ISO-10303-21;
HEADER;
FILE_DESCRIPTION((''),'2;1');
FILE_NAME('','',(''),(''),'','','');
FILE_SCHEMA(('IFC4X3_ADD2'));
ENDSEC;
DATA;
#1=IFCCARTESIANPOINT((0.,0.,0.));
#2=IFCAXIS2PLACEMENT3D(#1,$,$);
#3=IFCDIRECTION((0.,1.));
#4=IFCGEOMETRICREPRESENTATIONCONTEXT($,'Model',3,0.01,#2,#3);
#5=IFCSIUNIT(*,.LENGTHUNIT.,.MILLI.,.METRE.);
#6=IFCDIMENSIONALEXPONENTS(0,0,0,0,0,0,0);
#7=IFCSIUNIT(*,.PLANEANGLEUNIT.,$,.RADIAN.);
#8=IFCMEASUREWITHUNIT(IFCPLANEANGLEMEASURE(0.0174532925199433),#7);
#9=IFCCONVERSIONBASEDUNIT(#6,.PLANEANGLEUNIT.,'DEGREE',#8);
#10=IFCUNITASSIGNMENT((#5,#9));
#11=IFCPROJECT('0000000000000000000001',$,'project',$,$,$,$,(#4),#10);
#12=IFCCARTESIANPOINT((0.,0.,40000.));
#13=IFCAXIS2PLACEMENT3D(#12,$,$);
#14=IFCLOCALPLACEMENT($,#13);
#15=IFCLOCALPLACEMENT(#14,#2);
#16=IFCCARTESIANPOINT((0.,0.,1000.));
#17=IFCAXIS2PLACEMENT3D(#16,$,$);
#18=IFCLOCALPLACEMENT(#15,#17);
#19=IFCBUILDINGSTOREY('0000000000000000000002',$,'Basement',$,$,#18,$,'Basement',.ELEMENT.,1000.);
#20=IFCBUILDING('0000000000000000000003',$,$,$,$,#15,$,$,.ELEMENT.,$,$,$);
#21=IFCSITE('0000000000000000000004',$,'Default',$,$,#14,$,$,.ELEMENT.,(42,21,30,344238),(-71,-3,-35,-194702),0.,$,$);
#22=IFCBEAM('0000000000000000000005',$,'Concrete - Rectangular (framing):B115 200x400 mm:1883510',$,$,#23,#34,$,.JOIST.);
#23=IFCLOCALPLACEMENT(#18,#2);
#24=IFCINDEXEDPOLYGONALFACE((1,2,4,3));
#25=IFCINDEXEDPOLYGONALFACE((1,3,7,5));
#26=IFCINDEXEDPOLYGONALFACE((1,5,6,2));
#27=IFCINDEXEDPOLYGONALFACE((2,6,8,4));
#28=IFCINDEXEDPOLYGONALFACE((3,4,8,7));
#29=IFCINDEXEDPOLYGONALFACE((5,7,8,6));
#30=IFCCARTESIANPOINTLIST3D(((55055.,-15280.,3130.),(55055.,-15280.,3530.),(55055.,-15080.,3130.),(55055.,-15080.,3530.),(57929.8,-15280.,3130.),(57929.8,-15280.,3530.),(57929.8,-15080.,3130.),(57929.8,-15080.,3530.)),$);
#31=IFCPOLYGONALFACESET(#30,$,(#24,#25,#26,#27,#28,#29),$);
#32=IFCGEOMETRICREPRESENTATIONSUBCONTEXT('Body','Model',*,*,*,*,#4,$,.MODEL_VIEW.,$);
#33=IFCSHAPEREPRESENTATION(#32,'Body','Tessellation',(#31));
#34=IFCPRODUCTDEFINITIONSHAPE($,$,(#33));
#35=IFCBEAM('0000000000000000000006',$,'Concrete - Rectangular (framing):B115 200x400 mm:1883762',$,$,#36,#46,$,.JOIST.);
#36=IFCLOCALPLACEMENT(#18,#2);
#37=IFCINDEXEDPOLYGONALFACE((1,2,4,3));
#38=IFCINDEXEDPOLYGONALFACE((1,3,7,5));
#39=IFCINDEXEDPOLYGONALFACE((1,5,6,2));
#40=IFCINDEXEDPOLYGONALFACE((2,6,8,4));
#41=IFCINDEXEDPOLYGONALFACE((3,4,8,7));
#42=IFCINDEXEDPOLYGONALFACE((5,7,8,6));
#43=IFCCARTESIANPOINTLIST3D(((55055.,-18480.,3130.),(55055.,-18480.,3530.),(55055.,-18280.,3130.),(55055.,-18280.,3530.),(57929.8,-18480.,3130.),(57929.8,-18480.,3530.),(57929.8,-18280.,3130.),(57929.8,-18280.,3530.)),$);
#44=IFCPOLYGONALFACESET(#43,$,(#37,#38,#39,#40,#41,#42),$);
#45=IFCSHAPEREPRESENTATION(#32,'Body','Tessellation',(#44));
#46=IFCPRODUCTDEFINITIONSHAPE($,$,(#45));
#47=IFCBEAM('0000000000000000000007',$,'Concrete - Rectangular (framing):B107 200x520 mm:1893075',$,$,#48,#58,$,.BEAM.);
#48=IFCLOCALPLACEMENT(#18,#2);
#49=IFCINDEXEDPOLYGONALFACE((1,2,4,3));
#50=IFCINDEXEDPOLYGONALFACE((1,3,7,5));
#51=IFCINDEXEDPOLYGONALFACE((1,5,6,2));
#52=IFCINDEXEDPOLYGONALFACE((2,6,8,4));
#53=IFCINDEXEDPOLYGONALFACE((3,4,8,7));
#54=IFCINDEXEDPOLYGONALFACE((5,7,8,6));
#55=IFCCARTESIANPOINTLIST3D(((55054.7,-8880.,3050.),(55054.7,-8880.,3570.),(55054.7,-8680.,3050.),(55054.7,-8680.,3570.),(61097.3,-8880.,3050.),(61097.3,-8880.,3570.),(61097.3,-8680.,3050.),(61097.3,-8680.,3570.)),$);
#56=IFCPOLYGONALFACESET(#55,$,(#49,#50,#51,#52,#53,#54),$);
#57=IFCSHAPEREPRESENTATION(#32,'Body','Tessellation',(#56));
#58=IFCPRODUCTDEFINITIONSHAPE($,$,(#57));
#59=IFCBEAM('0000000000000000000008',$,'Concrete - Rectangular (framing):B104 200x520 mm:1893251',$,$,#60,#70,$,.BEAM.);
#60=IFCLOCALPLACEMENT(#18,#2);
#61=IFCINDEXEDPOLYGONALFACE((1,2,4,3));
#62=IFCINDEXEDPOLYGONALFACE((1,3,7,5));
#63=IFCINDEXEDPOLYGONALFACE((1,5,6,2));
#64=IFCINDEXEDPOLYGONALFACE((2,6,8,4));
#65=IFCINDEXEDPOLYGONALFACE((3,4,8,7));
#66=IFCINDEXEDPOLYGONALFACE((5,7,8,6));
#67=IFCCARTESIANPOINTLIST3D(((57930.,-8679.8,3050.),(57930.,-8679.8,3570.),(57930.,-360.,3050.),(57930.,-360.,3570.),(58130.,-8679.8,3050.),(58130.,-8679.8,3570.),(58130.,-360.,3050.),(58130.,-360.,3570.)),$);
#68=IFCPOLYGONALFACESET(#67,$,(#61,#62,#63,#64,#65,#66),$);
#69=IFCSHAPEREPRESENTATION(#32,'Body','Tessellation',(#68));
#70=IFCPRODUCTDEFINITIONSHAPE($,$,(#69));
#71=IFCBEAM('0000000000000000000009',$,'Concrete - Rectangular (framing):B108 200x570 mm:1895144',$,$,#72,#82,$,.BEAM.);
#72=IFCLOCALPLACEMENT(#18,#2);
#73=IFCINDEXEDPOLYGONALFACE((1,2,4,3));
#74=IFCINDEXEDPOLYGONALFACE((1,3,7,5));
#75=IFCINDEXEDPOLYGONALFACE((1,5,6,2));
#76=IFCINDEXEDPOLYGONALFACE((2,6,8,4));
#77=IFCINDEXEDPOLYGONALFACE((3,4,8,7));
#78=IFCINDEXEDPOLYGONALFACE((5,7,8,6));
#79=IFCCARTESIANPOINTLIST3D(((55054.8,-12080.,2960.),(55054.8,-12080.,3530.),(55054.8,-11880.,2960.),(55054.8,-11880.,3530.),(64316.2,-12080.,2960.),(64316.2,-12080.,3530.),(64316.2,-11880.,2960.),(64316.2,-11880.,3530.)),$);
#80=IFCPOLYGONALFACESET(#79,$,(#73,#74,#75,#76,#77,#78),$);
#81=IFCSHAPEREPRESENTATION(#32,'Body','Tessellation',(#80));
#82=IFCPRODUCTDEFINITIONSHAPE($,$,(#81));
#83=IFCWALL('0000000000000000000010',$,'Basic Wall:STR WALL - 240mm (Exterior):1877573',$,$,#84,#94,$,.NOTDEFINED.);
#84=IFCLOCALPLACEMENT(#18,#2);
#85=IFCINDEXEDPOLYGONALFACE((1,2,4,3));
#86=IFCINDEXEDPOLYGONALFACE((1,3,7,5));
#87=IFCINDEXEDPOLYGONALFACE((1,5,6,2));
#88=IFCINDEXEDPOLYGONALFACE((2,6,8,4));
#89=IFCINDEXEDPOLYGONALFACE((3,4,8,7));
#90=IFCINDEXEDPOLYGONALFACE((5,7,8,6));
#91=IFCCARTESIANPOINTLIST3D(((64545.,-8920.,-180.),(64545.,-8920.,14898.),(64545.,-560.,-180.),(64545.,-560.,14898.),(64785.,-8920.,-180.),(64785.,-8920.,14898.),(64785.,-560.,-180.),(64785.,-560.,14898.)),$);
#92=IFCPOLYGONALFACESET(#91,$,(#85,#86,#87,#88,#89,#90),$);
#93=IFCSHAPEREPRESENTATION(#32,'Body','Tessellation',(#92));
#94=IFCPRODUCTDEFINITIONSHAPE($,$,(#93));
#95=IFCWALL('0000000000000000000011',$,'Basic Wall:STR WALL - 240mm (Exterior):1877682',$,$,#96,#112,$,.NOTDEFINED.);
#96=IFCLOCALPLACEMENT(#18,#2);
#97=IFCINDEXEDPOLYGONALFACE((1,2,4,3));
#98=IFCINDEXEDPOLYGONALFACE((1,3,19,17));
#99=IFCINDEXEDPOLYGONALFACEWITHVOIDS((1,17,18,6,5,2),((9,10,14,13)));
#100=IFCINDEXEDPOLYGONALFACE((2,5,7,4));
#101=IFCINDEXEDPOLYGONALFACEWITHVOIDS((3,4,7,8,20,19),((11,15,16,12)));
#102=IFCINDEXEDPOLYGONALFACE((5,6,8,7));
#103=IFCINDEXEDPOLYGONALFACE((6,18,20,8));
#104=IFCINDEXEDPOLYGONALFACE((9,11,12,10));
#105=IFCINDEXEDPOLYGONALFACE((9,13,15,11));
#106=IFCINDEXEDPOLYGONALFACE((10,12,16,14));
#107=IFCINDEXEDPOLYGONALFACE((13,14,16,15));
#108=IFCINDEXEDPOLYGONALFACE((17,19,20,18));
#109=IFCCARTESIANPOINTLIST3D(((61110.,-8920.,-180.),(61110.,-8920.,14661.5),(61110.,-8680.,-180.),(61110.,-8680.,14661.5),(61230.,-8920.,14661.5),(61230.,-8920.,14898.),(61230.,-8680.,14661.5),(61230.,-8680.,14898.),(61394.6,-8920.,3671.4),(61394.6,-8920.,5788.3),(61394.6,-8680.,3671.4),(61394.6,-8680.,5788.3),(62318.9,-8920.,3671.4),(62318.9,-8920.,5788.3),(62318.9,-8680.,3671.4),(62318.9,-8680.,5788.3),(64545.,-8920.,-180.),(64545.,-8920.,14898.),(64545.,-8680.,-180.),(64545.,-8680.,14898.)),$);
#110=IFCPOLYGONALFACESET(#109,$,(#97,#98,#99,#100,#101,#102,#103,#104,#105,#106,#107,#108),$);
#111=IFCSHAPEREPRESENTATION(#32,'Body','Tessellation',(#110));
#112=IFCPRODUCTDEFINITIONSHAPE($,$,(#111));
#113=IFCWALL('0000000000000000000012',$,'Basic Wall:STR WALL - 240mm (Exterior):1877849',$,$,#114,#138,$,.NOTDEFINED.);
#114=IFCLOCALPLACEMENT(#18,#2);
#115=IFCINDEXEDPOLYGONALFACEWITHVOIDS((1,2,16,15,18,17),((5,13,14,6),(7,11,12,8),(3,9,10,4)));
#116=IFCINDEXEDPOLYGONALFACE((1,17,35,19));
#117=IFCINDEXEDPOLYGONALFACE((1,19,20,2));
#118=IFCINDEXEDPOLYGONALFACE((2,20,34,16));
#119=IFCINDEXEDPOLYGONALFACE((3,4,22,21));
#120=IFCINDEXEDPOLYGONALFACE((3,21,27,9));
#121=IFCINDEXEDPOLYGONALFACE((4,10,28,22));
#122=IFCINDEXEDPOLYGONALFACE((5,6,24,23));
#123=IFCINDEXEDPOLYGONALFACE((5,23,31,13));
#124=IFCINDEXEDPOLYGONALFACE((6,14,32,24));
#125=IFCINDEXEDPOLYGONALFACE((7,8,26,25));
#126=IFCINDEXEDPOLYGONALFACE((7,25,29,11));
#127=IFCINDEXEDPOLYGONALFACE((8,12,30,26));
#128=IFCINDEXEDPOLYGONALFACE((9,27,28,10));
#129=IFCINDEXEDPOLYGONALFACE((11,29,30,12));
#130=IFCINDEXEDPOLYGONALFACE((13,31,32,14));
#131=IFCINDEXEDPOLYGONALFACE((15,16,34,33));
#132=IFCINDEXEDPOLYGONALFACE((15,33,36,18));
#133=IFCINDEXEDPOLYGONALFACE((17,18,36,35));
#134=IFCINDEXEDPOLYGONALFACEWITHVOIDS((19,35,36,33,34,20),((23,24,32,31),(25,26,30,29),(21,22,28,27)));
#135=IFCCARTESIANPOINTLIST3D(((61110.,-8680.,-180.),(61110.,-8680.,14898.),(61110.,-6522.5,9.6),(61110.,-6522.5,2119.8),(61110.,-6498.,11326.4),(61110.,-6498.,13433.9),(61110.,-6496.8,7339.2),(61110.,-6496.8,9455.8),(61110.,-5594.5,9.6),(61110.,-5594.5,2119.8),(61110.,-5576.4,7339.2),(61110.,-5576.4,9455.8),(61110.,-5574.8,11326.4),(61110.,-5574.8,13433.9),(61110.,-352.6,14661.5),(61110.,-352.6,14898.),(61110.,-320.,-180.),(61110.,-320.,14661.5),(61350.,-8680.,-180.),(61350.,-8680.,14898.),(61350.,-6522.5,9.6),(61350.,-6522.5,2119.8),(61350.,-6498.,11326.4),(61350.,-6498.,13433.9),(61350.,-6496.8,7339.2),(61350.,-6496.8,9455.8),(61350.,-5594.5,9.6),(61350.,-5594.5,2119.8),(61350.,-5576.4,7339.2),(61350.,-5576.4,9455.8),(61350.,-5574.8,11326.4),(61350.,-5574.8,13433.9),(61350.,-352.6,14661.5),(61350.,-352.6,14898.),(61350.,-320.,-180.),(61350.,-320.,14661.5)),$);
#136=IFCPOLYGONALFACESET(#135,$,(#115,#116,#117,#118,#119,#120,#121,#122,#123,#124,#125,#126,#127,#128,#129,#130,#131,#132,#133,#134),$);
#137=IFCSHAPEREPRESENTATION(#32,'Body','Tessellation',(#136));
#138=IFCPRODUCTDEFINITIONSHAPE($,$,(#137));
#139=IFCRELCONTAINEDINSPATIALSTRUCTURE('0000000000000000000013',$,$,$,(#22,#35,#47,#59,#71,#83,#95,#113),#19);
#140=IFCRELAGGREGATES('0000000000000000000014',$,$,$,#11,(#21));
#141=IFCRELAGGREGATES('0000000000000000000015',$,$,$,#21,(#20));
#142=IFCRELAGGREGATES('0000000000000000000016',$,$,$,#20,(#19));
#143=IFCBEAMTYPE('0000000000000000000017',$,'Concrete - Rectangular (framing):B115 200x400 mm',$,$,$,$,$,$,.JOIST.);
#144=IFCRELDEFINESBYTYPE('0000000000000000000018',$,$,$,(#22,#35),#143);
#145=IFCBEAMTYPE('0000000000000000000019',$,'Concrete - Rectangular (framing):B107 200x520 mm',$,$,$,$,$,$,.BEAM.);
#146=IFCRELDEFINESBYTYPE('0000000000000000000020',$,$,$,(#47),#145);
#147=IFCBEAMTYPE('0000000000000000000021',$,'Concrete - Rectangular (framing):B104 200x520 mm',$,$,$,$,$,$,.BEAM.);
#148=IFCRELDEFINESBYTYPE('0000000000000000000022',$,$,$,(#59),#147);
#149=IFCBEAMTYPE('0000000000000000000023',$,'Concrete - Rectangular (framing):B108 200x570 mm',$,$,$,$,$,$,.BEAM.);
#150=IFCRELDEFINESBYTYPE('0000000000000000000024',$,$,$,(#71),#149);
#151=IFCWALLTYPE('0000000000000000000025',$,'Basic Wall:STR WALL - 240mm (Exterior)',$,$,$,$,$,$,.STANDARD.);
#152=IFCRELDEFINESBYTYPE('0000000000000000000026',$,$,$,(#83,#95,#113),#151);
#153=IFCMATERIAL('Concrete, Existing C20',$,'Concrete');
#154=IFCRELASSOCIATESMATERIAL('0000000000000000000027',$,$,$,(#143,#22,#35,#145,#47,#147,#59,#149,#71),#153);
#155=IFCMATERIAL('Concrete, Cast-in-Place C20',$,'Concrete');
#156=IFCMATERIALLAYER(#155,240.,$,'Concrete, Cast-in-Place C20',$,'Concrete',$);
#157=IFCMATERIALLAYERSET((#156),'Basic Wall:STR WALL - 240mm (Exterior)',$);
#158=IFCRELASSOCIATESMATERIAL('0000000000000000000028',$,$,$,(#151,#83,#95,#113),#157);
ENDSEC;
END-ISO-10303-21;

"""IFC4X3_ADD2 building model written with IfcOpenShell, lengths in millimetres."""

from ifc_helpers import new_model, entity, si_unit, converted_unit, direction, frame, frame_2d, origin, origin_2d_with_axis, place, context, subcontext, project, spatial, polyline, rectangle, extrude, clip, bounded_halfspace, source, transform, mapped, material, layer, layer_set, material_profile, profile_set, profile_usage, type_object, type_shapes, element, save


model = new_model("IFC4X3_ADD2")

# Units and contexts
model_context = context("Model", 3, precision=0.01, world=origin(), true_north=direction((0.0, 1.0)))
body_context = subcontext(model_context, "Body", "Model", "MODEL_VIEW")
ifc_project = project(units=[si_unit("LENGTHUNIT", "METRE", prefix="MILLI"), converted_unit("PLANEANGLEUNIT", "DEGREE", entity("IfcPlaneAngleMeasure", 0.0174532925199433), si_unit("PLANEANGLEUNIT", "RADIAN"), dimensions=[0, 0, 0, 0, 0, 0, 0])], contexts=[model_context])

# Site, building, storey
site_placement = place(None, frame((0.0, 0.0, 40000.0)))
site = spatial("IfcSite", under=ifc_project, at=site_placement, Name="Default", CompositionType="ELEMENT", RefLatitude=(42, 21, 30, 344238), RefLongitude=(-71, -3, -35, -194702), RefElevation=0.0)
building_placement = place(site_placement, origin())
building = spatial("IfcBuilding", under=site, at=building_placement, CompositionType="ELEMENT")
storey_placement = place(building_placement, frame((0.0, 0.0, 1000.0)))
storey = spatial("IfcBuildingStorey", under=building, at=storey_placement, Name="Basement", LongName="Basement", CompositionType="ELEMENT", Elevation=1000.0)

# Shared definitions
ifc_material_1 = material(Name="Concrete, Existing C20", Category="Concrete")

# Beams
ifc_material_profile_1 = material_profile(ifc_material_1, rectangle(XDim=2874.8, YDim=200.0, at=frame_2d((0.0, 0.0), x_axis=(1.0, 0.0))), Name="B115 200x400 mm")
ifc_profile_set_1 = profile_set([ifc_material_profile_1], Name="B115 200x400 mm")
ifc_profile_usage_1 = profile_usage(ifc_profile_set_1, cardinal=8)
beam_type_1 = type_object("IfcBeamType", Name="Concrete - Rectangular (framing):B115 200x400 mm", PredefinedType="JOIST", material=ifc_profile_set_1)
shared_shape_1 = source(origin(), body_context, "Body", "SweptSolid", [
    extrude(rectangle(XDim=2874.8, YDim=200.0, at=frame_2d((0.0, 0.0), x_axis=(1.0, 0.0))), frame((-125.1, 0.0, -200.0), z_axis=(0.0, 0.0, 1.0), x_axis=(-1.0, 0.0, 0.0)), (0.0, 0.0, 1.0), 400.0),
])
type_shapes(beam_type_1, [shared_shape_1])
for number, where, name in (
    (1, (56617.5, -15180.0, 3330.0), "Concrete - Rectangular (framing):B115 200x400 mm:1883510"),
    (2, (56617.5, -18380.0, 3330.0), "Concrete - Rectangular (framing):B115 200x400 mm:1883762"),
):
    element("IfcBeam", number, at=place(storey_placement, frame(where)), inside=storey, type_object=beam_type_1, material=ifc_profile_usage_1, Name=name, PredefinedType="JOIST", context=body_context, shape_type="MappedRepresentation", body=[
        mapped(shared_shape_1, transform((0.0, 0.0, 0.0), scale=1.0)),
    ])
ifc_material_profile_2 = material_profile(ifc_material_1, rectangle(XDim=6042.6, YDim=200.0, at=origin_2d_with_axis()), Name="B107 200x520 mm")
ifc_profile_set_2 = profile_set([ifc_material_profile_2], Name="B107 200x520 mm")
ifc_profile_usage_2 = profile_usage(ifc_profile_set_2, cardinal=8)
beam_type_2 = type_object("IfcBeamType", Name="Concrete - Rectangular (framing):B107 200x520 mm", PredefinedType="BEAM", material=ifc_profile_set_2)
shared_shape_2 = source(origin(), body_context, "Body", "SweptSolid", [
    extrude(rectangle(XDim=6042.6, YDim=200.0, at=origin_2d_with_axis()), frame((154.0, 0.0, -260.0), z_axis=(0.0, 0.0, 1.0), x_axis=(-1.0, 0.0, 0.0)), (0.0, 0.0, 1.0), 520.0),
])
type_shapes(beam_type_2, [shared_shape_2])
beam_1_placement = place(storey_placement, frame((58230.0, -8780.0, 3310.0), z_axis=(0.0, 0.0, 1.0), x_axis=(-1.0, 0.0, 0.0)))
element("IfcBeam", 3, at=beam_1_placement, inside=storey, type_object=beam_type_2, material=ifc_profile_usage_2, Name="Concrete - Rectangular (framing):B107 200x520 mm:1893075", PredefinedType="BEAM", context=body_context, shape_type="MappedRepresentation", body=[
    mapped(shared_shape_2, transform((0.0, 0.0, 0.0), scale=1.0)),
])
ifc_material_profile_3 = material_profile(ifc_material_1, rectangle(XDim=8319.8, YDim=200.0, at=origin_2d_with_axis()), Name="B104 200x520 mm")
ifc_profile_set_3 = profile_set([ifc_material_profile_3], Name="B104 200x520 mm")
ifc_profile_usage_3 = profile_usage(ifc_profile_set_3, cardinal=8)
beam_type_3 = type_object("IfcBeamType", Name="Concrete - Rectangular (framing):B104 200x520 mm", PredefinedType="BEAM", material=ifc_profile_set_3)
shared_shape_3 = source(origin(), body_context, "Body", "SweptSolid", [
    extrude(rectangle(XDim=8319.8, YDim=200.0, at=origin_2d_with_axis()), frame((-100.1, 0.0, -260.0), z_axis=(0.0, 0.0, 1.0), x_axis=(-1.0, 0.0, 0.0)), (0.0, 0.0, 1.0), 520.0),
])
type_shapes(beam_type_3, [shared_shape_3])
beam_2_placement = place(storey_placement, frame((58030.0, -4620.0, 3310.0), z_axis=(0.0, 0.0, 1.0), x_axis=(0.0, -1.0, 0.0)))
element("IfcBeam", 4, at=beam_2_placement, inside=storey, type_object=beam_type_3, material=ifc_profile_usage_3, Name="Concrete - Rectangular (framing):B104 200x520 mm:1893251", PredefinedType="BEAM", context=body_context, shape_type="MappedRepresentation", body=[
    mapped(shared_shape_3, transform((0.0, 0.0, 0.0), scale=1.0)),
])
ifc_material_profile_4 = material_profile(ifc_material_1, rectangle(XDim=9261.4, YDim=200.0, at=origin_2d_with_axis()), Name="B108 200x570 mm")
ifc_profile_set_4 = profile_set([ifc_material_profile_4], Name="B108 200x570 mm")
ifc_profile_usage_4 = profile_usage(ifc_profile_set_4, cardinal=8)
beam_type_4 = type_object("IfcBeamType", Name="Concrete - Rectangular (framing):B108 200x570 mm", PredefinedType="BEAM", material=ifc_profile_set_4)
shared_shape_4 = source(origin(), body_context, "Body", "SweptSolid", [
    extrude(rectangle(XDim=9261.4, YDim=200.0, at=origin_2d_with_axis()), frame((43.0, 0.0, -285.0), z_axis=(0.0, 0.0, 1.0), x_axis=(-1.0, 0.0, 0.0)), (0.0, 0.0, 1.0), 570.0),
])
type_shapes(beam_type_4, [shared_shape_4])
beam_3_placement = place(storey_placement, frame((59642.5, -11980.0, 3245.0)))
element("IfcBeam", 5, at=beam_3_placement, inside=storey, type_object=beam_type_4, material=ifc_profile_usage_4, Name="Concrete - Rectangular (framing):B108 200x570 mm:1895144", PredefinedType="BEAM", context=body_context, shape_type="MappedRepresentation", body=[
    mapped(shared_shape_4, transform((0.0, 0.0, 0.0), scale=1.0)),
])

# Wall
ifc_material_2 = material(Name="Concrete, Cast-in-Place C20", Category="Concrete")
ifc_layer = layer(ifc_material_2, 240.0, Name="Concrete, Cast-in-Place C20", Category="Concrete")
ifc_layer_set = layer_set([ifc_layer], Name="Basic Wall:STR WALL - 240mm (Exterior)")
wall_type = type_object("IfcWallType", Name="Basic Wall:STR WALL - 240mm (Exterior)", PredefinedType="STANDARD", material=ifc_layer_set)
wall_1_placement = place(storey_placement, frame((64665.0, -560.0, -180.0), z_axis=(0.0, 0.0, 1.0), x_axis=(0.0, -1.0, 0.0)))
element("IfcWall", 6, at=wall_1_placement, inside=storey, type_object=wall_type, material=ifc_layer_set, Name="Basic Wall:STR WALL - 240mm (Exterior):1877573", PredefinedType="NOTDEFINED", context=body_context, shape_type="SweptSolid", body=[
    extrude(rectangle(XDim=8360.0, YDim=240.0, at=frame_2d((4180.0, 0.0), x_axis=(-1.0, 0.0))), origin(), (0.0, 0.0, 1.0), 15078.0),
])

# Wall, opening
wall_2_placement = place(storey_placement, frame((64545.0, -8800.0, -180.0), z_axis=(0.0, 0.0, 1.0), x_axis=(-1.0, 0.0, 0.0)))
wall_2 = element("IfcWall", 7, at=wall_2_placement, inside=storey, type_object=wall_type, material=ifc_layer_set, Name="Basic Wall:STR WALL - 240mm (Exterior):1877682", PredefinedType="NOTDEFINED", context=body_context, shape_type="Clipping", body=[
    clip(clip(clip(clip(extrude(rectangle(XDim=3435.0, YDim=240.0, at=frame_2d((1717.5, 0.0), x_axis=(-1.0, 0.0))), origin(), (0.0, 0.0, 1.0), 15078.0), bounded_halfspace(frame((3315.0, -7.6, 15078.0), z_axis=(0.0, 0.0, -1.0), x_axis=(0.0, 1.0, 0.0)), True, frame((3315.0, -7.6, 15078.0)), polyline([(0.0, 0.0), (0.0, 127.6), (-3315.0, 127.6), (-3315.0, 0.0), (0.0, 0.0)]))), bounded_halfspace(frame((0.0, -120.0, 15078.0), z_axis=(0.0, 0.0, -1.0), x_axis=(0.0, 1.0, 0.0)), True, frame((0.0, -120.0, 15078.0)), polyline([(0.0, 0.0), (3195.0, 0.0), (3315.0, 0.0), (3315.0, 112.4), (0.0, 112.4), (0.0, 0.0)]))), bounded_halfspace(frame((3315.0, -120.0, 14841.5), z_axis=(0.0, 0.0, 1.0), x_axis=(0.0, 1.0, 0.0)), False, frame((3315.0, -120.0, 14841.5)), polyline([(0.0, 0.0), (120.0, 0.0), (120.0, 112.4), (0.0, 112.4), (0.0, 0.0)]))), bounded_halfspace(frame((3435.0, -7.6, 14841.5), z_axis=(0.0, 0.0, 1.0), x_axis=(0.0, 1.0, 0.0)), False, frame((3435.0, -7.6, 14841.5)), polyline([(0.0, 0.0), (0.0, 127.6), (-120.0, 127.6), (-120.0, 0.0), (0.0, 0.0)]))),
])
opening_1_placement = place(wall_2_placement, frame((3150.4, 120.0, 3851.4)))
element("IfcOpeningElement", 8, at=opening_1_placement, cuts=wall_2, PredefinedType="OPENING", context=body_context, shape_type="SweptSolid", body=[
    extrude(rectangle(XDim=2116.9, YDim=924.3, at=frame_2d((0.0, 0.0), x_axis=(1.0, 0.0))), frame((-462.1, -240.0, 1058.4), z_axis=(0.0, 1.0, 0.0), x_axis=(0.0, 0.0, -1.0)), (0.0, 0.0, 1.0), 240.0),
])

# Wall, openings
wall_3_placement = place(storey_placement, frame((61230.0, -8680.0, -180.0), z_axis=(0.0, 0.0, 1.0), x_axis=(0.0, 1.0, 0.0)))
wall_3 = element("IfcWall", 9, at=wall_3_placement, inside=storey, type_object=wall_type, material=ifc_layer_set, Name="Basic Wall:STR WALL - 240mm (Exterior):1877849", PredefinedType="NOTDEFINED", context=body_context, shape_type="Clipping", body=[
    clip(clip(clip(clip(extrude(rectangle(XDim=8360.0, YDim=240.0, at=frame_2d((4180.0, 0.0), x_axis=(-1.0, 0.0))), origin(), (0.0, 0.0, 1.0), 15078.0), bounded_halfspace(frame((0.0, -120.0, 15078.0), z_axis=(0.0, 0.0, -1.0), x_axis=(-1.0, 0.0, 0.0)), True, frame((0.0, -120.0, 15078.0)), polyline([(0.0, 0.0), (8120.0, 0.0), (8327.4, 0.0), (8327.4, 120.0), (0.0, 120.0), (0.0, 0.0)]))), bounded_halfspace(frame((8327.4, 120.0, 15078.0), z_axis=(0.0, 0.0, -1.0), x_axis=(-1.0, 0.0, 0.0)), True, frame((8327.4, 120.0, 15078.0)), polyline([(0.0, 0.0), (-8327.4, 0.0), (-8327.4, -120.0), (0.0, -120.0), (0.0, 0.0)]))), bounded_halfspace(frame((8327.4, -120.0, 14841.5), z_axis=(0.0, 0.0, 1.0), x_axis=(0.0, 1.0, 0.0)), False, frame((8327.4, -120.0, 14841.5)), polyline([(0.0, 0.0), (32.6, 0.0), (32.6, 120.0), (0.0, 120.0), (0.0, 0.0)]))), bounded_halfspace(frame((8360.0, 0.0, 14841.5), z_axis=(0.0, 0.0, 1.0), x_axis=(0.0, 1.0, 0.0)), False, frame((8360.0, 0.0, 14841.5)), polyline([(0.0, 0.0), (0.0, 120.0), (-32.6, 120.0), (-32.6, 0.0), (0.0, 0.0)]))),
])
opening_2_placement = place(wall_3_placement, frame((2182.0, 120.0, 11506.4)))
element("IfcOpeningElement", 10, at=opening_2_placement, cuts=wall_3, PredefinedType="OPENING", context=body_context, shape_type="SweptSolid", body=[
    extrude(rectangle(XDim=2107.5, YDim=923.2, at=origin_2d_with_axis()), frame((461.6, -240.0, 1053.8), z_axis=(0.0, 1.0, 0.0), x_axis=(0.0, 0.0, -1.0)), (0.0, 0.0, 1.0), 240.0),
])
opening_3_placement = place(wall_3_placement, frame((2183.2, 120.0, 7519.2)))
element("IfcOpeningElement", 11, at=opening_3_placement, cuts=wall_3, PredefinedType="OPENING", context=body_context, shape_type="SweptSolid", body=[
    extrude(rectangle(XDim=2116.6, YDim=920.4, at=frame_2d((0.0, 0.0), x_axis=(1.0, 0.0))), frame((460.2, -240.0, 1058.3), z_axis=(0.0, 1.0, 0.0), x_axis=(0.0, 0.0, -1.0)), (0.0, 0.0, 1.0), 240.0),
])
opening_4_placement = place(wall_3_placement, frame((2157.5, 120.0, 189.6)))
element("IfcOpeningElement", 12, at=opening_4_placement, cuts=wall_3, PredefinedType="OPENING", context=body_context, shape_type="SweptSolid", body=[
    extrude(rectangle(XDim=2110.2, YDim=928.0, at=frame_2d((0.0, 0.0), x_axis=(1.0, 0.0))), frame((464.0, -240.0, 1055.1), z_axis=(0.0, 1.0, 0.0), x_axis=(0.0, 0.0, -1.0)), (0.0, 0.0, 1.0), 240.0),
])

save(model, "model.ifc")
